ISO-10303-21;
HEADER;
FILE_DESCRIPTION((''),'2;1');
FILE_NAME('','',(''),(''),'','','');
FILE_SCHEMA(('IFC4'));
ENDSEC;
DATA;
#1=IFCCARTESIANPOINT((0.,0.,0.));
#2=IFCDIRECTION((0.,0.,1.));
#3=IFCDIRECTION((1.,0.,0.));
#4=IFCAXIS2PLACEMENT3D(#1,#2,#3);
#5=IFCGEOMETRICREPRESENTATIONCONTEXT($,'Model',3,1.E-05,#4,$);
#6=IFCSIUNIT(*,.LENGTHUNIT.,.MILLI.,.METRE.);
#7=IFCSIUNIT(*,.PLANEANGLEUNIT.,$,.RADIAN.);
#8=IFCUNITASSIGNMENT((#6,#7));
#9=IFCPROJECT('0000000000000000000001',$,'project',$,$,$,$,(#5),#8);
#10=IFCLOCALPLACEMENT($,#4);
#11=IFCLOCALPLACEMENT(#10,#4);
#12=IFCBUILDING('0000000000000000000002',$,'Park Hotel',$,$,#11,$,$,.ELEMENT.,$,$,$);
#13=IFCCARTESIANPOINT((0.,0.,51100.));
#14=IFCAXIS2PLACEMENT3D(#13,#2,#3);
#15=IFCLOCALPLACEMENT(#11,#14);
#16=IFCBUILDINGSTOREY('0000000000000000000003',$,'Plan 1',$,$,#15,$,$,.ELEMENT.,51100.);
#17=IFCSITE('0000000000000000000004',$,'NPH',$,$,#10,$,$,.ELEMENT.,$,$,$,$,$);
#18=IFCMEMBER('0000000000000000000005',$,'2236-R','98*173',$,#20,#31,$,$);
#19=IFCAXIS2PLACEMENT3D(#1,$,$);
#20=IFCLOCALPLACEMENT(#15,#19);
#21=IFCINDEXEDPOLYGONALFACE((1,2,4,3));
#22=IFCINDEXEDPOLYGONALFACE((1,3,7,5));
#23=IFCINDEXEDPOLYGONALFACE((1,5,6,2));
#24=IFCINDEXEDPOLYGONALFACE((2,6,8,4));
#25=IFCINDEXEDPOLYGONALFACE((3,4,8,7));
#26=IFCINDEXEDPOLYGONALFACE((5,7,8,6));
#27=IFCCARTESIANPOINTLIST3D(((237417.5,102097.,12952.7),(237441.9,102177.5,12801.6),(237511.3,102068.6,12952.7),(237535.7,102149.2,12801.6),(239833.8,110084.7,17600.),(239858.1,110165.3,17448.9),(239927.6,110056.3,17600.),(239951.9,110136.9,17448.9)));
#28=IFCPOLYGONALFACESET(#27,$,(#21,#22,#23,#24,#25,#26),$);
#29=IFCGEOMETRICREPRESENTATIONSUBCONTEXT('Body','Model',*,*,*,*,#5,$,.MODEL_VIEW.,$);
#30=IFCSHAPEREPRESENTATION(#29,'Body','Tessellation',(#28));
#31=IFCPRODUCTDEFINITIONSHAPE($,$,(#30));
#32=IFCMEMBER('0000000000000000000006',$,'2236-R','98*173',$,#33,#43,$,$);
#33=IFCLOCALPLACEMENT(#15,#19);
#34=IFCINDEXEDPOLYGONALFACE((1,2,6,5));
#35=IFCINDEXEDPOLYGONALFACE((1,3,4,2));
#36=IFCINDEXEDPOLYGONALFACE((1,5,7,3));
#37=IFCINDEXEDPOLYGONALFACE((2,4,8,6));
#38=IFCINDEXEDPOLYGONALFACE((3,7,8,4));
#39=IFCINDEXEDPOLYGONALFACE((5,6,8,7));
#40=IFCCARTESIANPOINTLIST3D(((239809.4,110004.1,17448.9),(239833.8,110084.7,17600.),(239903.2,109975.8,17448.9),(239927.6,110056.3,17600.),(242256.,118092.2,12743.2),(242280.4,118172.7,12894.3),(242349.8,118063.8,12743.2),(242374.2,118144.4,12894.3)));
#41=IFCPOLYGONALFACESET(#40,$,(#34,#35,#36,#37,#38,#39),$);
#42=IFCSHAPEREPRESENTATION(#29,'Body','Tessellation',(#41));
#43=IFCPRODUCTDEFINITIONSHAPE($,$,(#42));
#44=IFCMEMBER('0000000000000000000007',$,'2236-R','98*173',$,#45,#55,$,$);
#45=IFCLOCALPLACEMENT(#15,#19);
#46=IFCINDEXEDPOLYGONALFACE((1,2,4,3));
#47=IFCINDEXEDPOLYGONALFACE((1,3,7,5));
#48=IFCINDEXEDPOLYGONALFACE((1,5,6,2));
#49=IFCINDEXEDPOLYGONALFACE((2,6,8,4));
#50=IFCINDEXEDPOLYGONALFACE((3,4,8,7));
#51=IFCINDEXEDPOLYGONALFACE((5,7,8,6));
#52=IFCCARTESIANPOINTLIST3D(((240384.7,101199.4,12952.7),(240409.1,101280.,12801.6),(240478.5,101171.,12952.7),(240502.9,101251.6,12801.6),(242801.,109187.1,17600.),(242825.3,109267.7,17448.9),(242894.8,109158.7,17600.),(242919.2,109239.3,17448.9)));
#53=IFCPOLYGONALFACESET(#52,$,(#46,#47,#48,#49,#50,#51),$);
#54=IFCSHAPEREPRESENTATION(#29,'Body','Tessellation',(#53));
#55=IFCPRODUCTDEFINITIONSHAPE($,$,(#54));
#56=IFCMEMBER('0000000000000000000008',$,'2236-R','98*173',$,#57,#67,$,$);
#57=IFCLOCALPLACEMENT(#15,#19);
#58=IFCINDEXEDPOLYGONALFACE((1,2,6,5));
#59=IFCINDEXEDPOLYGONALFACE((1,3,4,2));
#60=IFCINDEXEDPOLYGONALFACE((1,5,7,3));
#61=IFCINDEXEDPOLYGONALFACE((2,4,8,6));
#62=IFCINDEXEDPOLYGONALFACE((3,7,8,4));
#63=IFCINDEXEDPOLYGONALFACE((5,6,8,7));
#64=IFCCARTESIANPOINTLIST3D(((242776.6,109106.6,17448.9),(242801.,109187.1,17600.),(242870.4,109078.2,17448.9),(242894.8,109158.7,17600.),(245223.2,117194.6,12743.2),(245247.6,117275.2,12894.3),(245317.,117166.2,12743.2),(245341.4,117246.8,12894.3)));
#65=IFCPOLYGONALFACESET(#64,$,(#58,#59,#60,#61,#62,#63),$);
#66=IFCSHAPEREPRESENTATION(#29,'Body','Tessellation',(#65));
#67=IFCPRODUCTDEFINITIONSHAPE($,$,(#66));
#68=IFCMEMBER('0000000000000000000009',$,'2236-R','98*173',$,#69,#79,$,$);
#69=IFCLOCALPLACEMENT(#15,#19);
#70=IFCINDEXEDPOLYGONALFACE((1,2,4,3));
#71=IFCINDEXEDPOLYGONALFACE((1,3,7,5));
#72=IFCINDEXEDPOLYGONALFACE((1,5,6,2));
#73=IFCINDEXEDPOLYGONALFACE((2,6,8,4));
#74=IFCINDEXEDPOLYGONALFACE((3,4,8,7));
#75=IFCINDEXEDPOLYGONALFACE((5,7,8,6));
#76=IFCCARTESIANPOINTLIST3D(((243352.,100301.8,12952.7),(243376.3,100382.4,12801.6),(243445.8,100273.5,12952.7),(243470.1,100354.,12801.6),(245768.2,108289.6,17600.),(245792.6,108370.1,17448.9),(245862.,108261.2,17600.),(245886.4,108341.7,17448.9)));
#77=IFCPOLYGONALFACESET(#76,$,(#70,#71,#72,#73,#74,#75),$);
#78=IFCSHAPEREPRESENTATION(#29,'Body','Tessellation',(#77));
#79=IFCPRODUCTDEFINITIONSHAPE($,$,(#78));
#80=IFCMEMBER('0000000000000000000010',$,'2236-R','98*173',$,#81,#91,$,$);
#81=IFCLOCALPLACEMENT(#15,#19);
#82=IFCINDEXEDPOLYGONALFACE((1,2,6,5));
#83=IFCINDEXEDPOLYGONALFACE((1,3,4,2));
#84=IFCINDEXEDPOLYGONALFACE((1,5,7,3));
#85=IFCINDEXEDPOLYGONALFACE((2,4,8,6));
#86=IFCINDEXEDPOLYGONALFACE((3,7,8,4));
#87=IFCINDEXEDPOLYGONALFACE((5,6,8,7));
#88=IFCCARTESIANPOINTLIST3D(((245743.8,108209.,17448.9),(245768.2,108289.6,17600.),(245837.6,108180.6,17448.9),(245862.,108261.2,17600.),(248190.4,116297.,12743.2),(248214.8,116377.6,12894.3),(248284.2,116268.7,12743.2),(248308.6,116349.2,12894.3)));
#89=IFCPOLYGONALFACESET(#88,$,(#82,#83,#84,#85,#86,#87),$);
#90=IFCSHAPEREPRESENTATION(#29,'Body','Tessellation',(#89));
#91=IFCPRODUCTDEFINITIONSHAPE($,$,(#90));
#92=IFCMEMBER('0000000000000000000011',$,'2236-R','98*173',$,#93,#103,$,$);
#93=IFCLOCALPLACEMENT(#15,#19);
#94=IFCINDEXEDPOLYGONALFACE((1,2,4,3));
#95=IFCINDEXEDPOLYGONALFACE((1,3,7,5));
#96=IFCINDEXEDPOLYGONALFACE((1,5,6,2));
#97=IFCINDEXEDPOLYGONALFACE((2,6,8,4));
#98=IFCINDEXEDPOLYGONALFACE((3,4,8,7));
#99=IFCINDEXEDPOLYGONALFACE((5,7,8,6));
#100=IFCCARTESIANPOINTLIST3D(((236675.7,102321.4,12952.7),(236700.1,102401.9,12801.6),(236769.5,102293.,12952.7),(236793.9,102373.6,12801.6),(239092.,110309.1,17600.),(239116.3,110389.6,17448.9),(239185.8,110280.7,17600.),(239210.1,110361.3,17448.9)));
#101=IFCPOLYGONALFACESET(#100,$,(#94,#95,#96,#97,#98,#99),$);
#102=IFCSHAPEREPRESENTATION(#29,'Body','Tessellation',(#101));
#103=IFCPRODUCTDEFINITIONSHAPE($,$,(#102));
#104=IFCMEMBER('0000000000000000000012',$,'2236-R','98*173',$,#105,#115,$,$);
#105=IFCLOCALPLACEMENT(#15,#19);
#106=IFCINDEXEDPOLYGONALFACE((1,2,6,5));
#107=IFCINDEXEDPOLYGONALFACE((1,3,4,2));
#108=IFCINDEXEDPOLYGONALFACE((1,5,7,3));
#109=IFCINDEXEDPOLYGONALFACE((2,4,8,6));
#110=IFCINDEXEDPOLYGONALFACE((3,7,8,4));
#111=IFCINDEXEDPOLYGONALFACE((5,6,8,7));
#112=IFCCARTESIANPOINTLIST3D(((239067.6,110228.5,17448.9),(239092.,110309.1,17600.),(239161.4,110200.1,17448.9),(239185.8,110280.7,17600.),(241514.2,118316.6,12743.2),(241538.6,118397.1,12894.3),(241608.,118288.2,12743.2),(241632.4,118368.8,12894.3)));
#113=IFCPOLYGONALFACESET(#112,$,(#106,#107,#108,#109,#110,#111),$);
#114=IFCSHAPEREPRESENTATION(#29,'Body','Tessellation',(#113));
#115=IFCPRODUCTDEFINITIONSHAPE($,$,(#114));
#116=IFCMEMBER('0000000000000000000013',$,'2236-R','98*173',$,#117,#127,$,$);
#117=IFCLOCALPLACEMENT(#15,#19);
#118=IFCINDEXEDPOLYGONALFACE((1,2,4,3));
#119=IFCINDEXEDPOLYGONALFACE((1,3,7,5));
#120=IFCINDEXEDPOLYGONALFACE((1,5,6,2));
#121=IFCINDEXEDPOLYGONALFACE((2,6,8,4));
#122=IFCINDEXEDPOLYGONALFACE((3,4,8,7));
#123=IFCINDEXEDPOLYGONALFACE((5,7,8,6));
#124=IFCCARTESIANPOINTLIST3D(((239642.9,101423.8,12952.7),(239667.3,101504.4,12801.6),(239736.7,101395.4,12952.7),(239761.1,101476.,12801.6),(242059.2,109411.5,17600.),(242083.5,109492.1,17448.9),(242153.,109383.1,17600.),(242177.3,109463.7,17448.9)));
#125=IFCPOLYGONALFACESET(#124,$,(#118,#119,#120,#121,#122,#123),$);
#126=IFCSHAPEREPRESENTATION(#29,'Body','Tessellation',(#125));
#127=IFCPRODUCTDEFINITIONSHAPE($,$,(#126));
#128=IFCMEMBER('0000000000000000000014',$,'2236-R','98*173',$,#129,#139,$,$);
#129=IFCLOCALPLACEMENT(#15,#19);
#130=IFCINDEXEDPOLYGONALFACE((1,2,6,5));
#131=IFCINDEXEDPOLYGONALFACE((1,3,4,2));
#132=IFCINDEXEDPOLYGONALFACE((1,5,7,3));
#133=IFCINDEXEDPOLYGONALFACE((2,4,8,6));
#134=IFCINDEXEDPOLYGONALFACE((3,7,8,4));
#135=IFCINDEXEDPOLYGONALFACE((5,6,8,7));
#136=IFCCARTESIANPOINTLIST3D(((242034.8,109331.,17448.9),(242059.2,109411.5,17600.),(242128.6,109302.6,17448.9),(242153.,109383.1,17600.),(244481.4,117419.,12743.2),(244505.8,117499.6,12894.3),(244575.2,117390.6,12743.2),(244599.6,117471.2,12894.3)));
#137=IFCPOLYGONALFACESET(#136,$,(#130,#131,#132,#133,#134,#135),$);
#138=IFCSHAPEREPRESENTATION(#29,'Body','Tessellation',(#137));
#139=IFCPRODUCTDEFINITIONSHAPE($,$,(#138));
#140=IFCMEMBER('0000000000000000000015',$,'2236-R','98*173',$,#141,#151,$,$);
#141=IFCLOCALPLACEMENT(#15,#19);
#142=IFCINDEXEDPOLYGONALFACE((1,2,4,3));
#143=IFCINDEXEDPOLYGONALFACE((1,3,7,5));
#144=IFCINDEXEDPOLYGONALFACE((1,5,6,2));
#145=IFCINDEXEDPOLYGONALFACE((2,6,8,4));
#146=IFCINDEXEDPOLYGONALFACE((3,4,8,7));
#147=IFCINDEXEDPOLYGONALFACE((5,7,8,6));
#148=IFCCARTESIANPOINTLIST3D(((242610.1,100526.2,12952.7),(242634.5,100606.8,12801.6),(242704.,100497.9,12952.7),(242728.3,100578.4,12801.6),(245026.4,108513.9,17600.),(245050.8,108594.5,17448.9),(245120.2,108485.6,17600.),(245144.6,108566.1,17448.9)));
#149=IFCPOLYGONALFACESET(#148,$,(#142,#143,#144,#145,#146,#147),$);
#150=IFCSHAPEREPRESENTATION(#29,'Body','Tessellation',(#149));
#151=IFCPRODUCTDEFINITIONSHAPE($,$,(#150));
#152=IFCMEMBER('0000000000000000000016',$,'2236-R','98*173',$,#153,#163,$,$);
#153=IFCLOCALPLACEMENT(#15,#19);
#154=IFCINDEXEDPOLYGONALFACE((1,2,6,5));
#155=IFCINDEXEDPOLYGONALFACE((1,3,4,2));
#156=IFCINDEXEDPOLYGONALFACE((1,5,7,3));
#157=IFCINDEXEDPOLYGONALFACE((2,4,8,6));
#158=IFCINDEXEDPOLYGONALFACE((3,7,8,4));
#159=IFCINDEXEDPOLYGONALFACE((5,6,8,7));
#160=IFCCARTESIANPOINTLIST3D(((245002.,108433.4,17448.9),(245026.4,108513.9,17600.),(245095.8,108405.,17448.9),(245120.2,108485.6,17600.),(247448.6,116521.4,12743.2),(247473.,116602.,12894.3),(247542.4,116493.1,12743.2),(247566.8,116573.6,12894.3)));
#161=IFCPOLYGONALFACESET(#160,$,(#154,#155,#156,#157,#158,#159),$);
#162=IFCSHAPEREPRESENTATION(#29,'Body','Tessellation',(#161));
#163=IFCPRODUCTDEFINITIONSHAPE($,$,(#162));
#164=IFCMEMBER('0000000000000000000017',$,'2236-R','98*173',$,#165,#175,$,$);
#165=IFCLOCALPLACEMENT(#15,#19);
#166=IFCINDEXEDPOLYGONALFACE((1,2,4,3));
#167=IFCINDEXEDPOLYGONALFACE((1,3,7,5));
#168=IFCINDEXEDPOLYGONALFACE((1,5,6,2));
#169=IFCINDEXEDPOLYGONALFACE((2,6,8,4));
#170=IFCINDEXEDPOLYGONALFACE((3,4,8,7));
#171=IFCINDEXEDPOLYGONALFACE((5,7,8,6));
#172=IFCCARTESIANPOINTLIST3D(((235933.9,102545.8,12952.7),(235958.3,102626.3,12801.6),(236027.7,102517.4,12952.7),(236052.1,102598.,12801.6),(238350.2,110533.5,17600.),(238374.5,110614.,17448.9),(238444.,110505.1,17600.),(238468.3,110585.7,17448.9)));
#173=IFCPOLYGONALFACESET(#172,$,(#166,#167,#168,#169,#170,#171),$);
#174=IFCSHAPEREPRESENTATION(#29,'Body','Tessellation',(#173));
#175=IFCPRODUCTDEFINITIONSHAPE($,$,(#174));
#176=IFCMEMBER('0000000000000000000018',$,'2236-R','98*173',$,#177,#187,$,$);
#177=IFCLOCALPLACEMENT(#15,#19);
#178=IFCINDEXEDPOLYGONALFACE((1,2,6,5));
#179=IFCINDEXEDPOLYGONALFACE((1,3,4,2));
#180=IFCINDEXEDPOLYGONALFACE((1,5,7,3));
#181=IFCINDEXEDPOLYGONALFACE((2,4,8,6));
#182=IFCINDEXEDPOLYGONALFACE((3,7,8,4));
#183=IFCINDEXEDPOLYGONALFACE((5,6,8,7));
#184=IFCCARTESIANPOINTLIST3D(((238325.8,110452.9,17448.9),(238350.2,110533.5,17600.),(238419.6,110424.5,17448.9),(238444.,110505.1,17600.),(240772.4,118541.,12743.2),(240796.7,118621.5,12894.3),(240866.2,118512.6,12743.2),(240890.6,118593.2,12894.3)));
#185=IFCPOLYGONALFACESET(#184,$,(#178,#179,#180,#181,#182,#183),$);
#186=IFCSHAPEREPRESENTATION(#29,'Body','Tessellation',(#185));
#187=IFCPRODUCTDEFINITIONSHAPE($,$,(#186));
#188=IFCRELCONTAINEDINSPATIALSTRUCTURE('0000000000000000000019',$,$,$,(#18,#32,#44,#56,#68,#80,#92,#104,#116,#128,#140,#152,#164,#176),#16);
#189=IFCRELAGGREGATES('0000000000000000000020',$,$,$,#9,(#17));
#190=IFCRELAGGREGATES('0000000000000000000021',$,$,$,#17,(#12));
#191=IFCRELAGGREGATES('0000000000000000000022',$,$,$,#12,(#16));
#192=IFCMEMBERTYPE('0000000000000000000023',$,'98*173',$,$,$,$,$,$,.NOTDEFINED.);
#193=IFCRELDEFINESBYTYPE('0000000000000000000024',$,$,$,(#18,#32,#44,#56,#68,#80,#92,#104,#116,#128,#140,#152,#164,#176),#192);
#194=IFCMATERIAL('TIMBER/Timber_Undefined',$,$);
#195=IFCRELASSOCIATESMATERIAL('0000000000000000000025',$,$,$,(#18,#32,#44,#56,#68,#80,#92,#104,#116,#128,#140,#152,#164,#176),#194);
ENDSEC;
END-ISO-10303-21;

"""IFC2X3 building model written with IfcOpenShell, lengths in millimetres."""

from ifc_helpers import new_model, si_unit, frame, origin_with_axes, origin_2d_with_axis, place, context, subcontext, project, spatial, rectangle, extrude, material, type_object, element, save


model = new_model("IFC2X3")

# Units and contexts
model_context = context("Model", 3, precision=1e-05, world=origin_with_axes())
body_context = subcontext(model_context, "Body", "Model", "MODEL_VIEW")
ifc_project = project(units=[si_unit("LENGTHUNIT", "METRE", prefix="MILLI"), si_unit("PLANEANGLEUNIT", "RADIAN")], contexts=[model_context])

# Site, building, storey
site_placement = place(None, origin_with_axes())
site = spatial("IfcSite", under=ifc_project, at=site_placement, Name="NPH", CompositionType="ELEMENT")
building_placement = place(site_placement, origin_with_axes())
building = spatial("IfcBuilding", under=site, at=building_placement, Name="Park Hotel", CompositionType="ELEMENT")
storey_placement = place(building_placement, frame((0.0, 0.0, 51100.0), z_axis=(0.0, 0.0, 1.0), x_axis=(1.0, 0.0, 0.0)))
storey = spatial("IfcBuildingStorey", under=building, at=storey_placement, Name="Plan 1", CompositionType="ELEMENT", Elevation=51100.0)

# Members
ifc_material = material(Name="TIMBER/Timber_Undefined")
member_type = type_object("IfcMemberType", Name="98*173", PredefinedType="NOTDEFINED")
member_1_placement = place(storey_placement, frame((239892.8, 110110.8, 17524.4), z_axis=(-0.957167, 0.289538, 0.0), x_axis=(-0.252959, -0.836241, -0.486531)))
element("IfcMember", 1, at=member_1_placement, inside=storey, type_object=member_type, material=ifc_material, Name="2236-R", Description="98*173", context=body_context, shape_type="SweptSolid", body=[
    extrude(rectangle(XDim=173.0, YDim=98.0, at=origin_2d_with_axis()), frame((9551.9, 0.0, 0.0), z_axis=(-1.0, 0.0, 0.0), x_axis=(0.0, -1.0, 0.0)), (0.0, 0.0, 1.0), 9551.9),
])
member_2_placement = place(storey_placement, frame((239868.5, 110030.2, 17524.4), z_axis=(-0.957167, 0.289538, 0.0), x_axis=(0.252959, 0.836242, -0.48653)))
element("IfcMember", 2, at=member_2_placement, inside=storey, type_object=member_type, material=ifc_material, Name="2236-R", Description="98*173", context=body_context, shape_type="SweptSolid", body=[
    extrude(rectangle(XDim=173.0, YDim=98.0, at=origin_2d_with_axis()), frame((9671.9, 0.0, 0.0), z_axis=(-1.0, 0.0, 0.0), x_axis=(0.0, -1.0, 0.0)), (0.0, 0.0, 1.0), 9671.9),
])
member_3_placement = place(storey_placement, frame((242860.1, 109213.2, 17524.4), z_axis=(-0.957167, 0.289538, 0.0), x_axis=(-0.252959, -0.836241, -0.486531)))
element("IfcMember", 3, at=member_3_placement, inside=storey, type_object=member_type, material=ifc_material, Name="2236-R", Description="98*173", context=body_context, shape_type="SweptSolid", body=[
    extrude(rectangle(XDim=173.0, YDim=98.0, at=origin_2d_with_axis()), frame((9551.9, 0.0, 0.0), z_axis=(-1.0, 0.0, 0.0), x_axis=(0.0, -1.0, 0.0)), (0.0, 0.0, 1.0), 9551.9),
])
member_4_placement = place(storey_placement, frame((242835.7, 109132.7, 17524.4), z_axis=(-0.957167, 0.289538, 0.0), x_axis=(0.252959, 0.836242, -0.48653)))
element("IfcMember", 4, at=member_4_placement, inside=storey, type_object=member_type, material=ifc_material, Name="2236-R", Description="98*173", context=body_context, shape_type="SweptSolid", body=[
    extrude(rectangle(XDim=173.0, YDim=98.0, at=origin_2d_with_axis()), frame((9671.9, 0.0, 0.0), z_axis=(-1.0, 0.0, 0.0), x_axis=(0.0, -1.0, 0.0)), (0.0, 0.0, 1.0), 9671.9),
])
member_5_placement = place(storey_placement, frame((245827.3, 108315.6, 17524.4), z_axis=(-0.957167, 0.289538, 0.0), x_axis=(-0.252959, -0.836241, -0.486531)))
element("IfcMember", 5, at=member_5_placement, inside=storey, type_object=member_type, material=ifc_material, Name="2236-R", Description="98*173", context=body_context, shape_type="SweptSolid", body=[
    extrude(rectangle(XDim=173.0, YDim=98.0, at=origin_2d_with_axis()), frame((9551.9, 0.0, 0.0), z_axis=(-1.0, 0.0, 0.0), x_axis=(0.0, -1.0, 0.0)), (0.0, 0.0, 1.0), 9551.9),
])
member_6_placement = place(storey_placement, frame((245802.9, 108235.1, 17524.4), z_axis=(-0.957167, 0.289538, 0.0), x_axis=(0.252959, 0.836242, -0.48653)))
element("IfcMember", 6, at=member_6_placement, inside=storey, type_object=member_type, material=ifc_material, Name="2236-R", Description="98*173", context=body_context, shape_type="SweptSolid", body=[
    extrude(rectangle(XDim=173.0, YDim=98.0, at=origin_2d_with_axis()), frame((9671.9, 0.0, 0.0), z_axis=(-1.0, 0.0, 0.0), x_axis=(0.0, -1.0, 0.0)), (0.0, 0.0, 1.0), 9671.9),
])
member_7_placement = place(storey_placement, frame((239151.0, 110335.2, 17524.4), z_axis=(-0.957167, 0.289538, 0.0), x_axis=(-0.252959, -0.836241, -0.486531)))
element("IfcMember", 7, at=member_7_placement, inside=storey, type_object=member_type, material=ifc_material, Name="2236-R", Description="98*173", context=body_context, shape_type="SweptSolid", body=[
    extrude(rectangle(XDim=173.0, YDim=98.0, at=origin_2d_with_axis()), frame((9551.9, 0.0, 0.0), z_axis=(-1.0, 0.0, 0.0), x_axis=(0.0, -1.0, 0.0)), (0.0, 0.0, 1.0), 9551.9),
])
member_8_placement = place(storey_placement, frame((239126.7, 110254.6, 17524.4), z_axis=(-0.957167, 0.289538, 0.0), x_axis=(0.252959, 0.836242, -0.48653)))
element("IfcMember", 8, at=member_8_placement, inside=storey, type_object=member_type, material=ifc_material, Name="2236-R", Description="98*173", context=body_context, shape_type="SweptSolid", body=[
    extrude(rectangle(XDim=173.0, YDim=98.0, at=origin_2d_with_axis()), frame((9671.9, 0.0, 0.0), z_axis=(-1.0, 0.0, 0.0), x_axis=(0.0, -1.0, 0.0)), (0.0, 0.0, 1.0), 9671.9),
])
member_9_placement = place(storey_placement, frame((242118.3, 109437.6, 17524.4), z_axis=(-0.957167, 0.289538, 0.0), x_axis=(-0.252959, -0.836241, -0.486531)))
element("IfcMember", 9, at=member_9_placement, inside=storey, type_object=member_type, material=ifc_material, Name="2236-R", Description="98*173", context=body_context, shape_type="SweptSolid", body=[
    extrude(rectangle(XDim=173.0, YDim=98.0, at=origin_2d_with_axis()), frame((9551.9, 0.0, 0.0), z_axis=(-1.0, 0.0, 0.0), x_axis=(0.0, -1.0, 0.0)), (0.0, 0.0, 1.0), 9551.9),
])
member_10_placement = place(storey_placement, frame((242093.9, 109357.0, 17524.4), z_axis=(-0.957167, 0.289538, 0.0), x_axis=(0.252959, 0.836242, -0.48653)))
element("IfcMember", 10, at=member_10_placement, inside=storey, type_object=member_type, material=ifc_material, Name="2236-R", Description="98*173", context=body_context, shape_type="SweptSolid", body=[
    extrude(rectangle(XDim=173.0, YDim=98.0, at=origin_2d_with_axis()), frame((9671.9, 0.0, 0.0), z_axis=(-1.0, 0.0, 0.0), x_axis=(0.0, -1.0, 0.0)), (0.0, 0.0, 1.0), 9671.9),
])
member_11_placement = place(storey_placement, frame((245085.5, 108540.0, 17524.4), z_axis=(-0.957167, 0.289538, 0.0), x_axis=(-0.252959, -0.836241, -0.486531)))
element("IfcMember", 11, at=member_11_placement, inside=storey, type_object=member_type, material=ifc_material, Name="2236-R", Description="98*173", context=body_context, shape_type="SweptSolid", body=[
    extrude(rectangle(XDim=173.0, YDim=98.0, at=origin_2d_with_axis()), frame((9551.9, 0.0, 0.0), z_axis=(-1.0, 0.0, 0.0), x_axis=(0.0, -1.0, 0.0)), (0.0, 0.0, 1.0), 9551.9),
])
member_12_placement = place(storey_placement, frame((245061.1, 108459.5, 17524.4), z_axis=(-0.957167, 0.289538, 0.0), x_axis=(0.252959, 0.836242, -0.48653)))
element("IfcMember", 12, at=member_12_placement, inside=storey, type_object=member_type, material=ifc_material, Name="2236-R", Description="98*173", context=body_context, shape_type="SweptSolid", body=[
    extrude(rectangle(XDim=173.0, YDim=98.0, at=origin_2d_with_axis()), frame((9671.9, 0.0, 0.0), z_axis=(-1.0, 0.0, 0.0), x_axis=(0.0, -1.0, 0.0)), (0.0, 0.0, 1.0), 9671.9),
])
member_13_placement = place(storey_placement, frame((238409.2, 110559.6, 17524.4), z_axis=(-0.957167, 0.289538, 0.0), x_axis=(-0.252959, -0.836241, -0.486531)))
element("IfcMember", 13, at=member_13_placement, inside=storey, type_object=member_type, material=ifc_material, Name="2236-R", Description="98*173", context=body_context, shape_type="SweptSolid", body=[
    extrude(rectangle(XDim=173.0, YDim=98.0, at=origin_2d_with_axis()), frame((9551.9, 0.0, 0.0), z_axis=(-1.0, 0.0, 0.0), x_axis=(0.0, -1.0, 0.0)), (0.0, 0.0, 1.0), 9551.9),
])
member_14_placement = place(storey_placement, frame((238384.9, 110479.0, 17524.4), z_axis=(-0.957167, 0.289538, 0.0), x_axis=(0.252959, 0.836242, -0.48653)))
element("IfcMember", 14, at=member_14_placement, inside=storey, type_object=member_type, material=ifc_material, Name="2236-R", Description="98*173", context=body_context, shape_type="SweptSolid", body=[
    extrude(rectangle(XDim=173.0, YDim=98.0, at=origin_2d_with_axis()), frame((9671.9, 0.0, 0.0), z_axis=(-1.0, 0.0, 0.0), x_axis=(0.0, -1.0, 0.0)), (0.0, 0.0, 1.0), 9671.9),
])

save(model, "model.ifc")
